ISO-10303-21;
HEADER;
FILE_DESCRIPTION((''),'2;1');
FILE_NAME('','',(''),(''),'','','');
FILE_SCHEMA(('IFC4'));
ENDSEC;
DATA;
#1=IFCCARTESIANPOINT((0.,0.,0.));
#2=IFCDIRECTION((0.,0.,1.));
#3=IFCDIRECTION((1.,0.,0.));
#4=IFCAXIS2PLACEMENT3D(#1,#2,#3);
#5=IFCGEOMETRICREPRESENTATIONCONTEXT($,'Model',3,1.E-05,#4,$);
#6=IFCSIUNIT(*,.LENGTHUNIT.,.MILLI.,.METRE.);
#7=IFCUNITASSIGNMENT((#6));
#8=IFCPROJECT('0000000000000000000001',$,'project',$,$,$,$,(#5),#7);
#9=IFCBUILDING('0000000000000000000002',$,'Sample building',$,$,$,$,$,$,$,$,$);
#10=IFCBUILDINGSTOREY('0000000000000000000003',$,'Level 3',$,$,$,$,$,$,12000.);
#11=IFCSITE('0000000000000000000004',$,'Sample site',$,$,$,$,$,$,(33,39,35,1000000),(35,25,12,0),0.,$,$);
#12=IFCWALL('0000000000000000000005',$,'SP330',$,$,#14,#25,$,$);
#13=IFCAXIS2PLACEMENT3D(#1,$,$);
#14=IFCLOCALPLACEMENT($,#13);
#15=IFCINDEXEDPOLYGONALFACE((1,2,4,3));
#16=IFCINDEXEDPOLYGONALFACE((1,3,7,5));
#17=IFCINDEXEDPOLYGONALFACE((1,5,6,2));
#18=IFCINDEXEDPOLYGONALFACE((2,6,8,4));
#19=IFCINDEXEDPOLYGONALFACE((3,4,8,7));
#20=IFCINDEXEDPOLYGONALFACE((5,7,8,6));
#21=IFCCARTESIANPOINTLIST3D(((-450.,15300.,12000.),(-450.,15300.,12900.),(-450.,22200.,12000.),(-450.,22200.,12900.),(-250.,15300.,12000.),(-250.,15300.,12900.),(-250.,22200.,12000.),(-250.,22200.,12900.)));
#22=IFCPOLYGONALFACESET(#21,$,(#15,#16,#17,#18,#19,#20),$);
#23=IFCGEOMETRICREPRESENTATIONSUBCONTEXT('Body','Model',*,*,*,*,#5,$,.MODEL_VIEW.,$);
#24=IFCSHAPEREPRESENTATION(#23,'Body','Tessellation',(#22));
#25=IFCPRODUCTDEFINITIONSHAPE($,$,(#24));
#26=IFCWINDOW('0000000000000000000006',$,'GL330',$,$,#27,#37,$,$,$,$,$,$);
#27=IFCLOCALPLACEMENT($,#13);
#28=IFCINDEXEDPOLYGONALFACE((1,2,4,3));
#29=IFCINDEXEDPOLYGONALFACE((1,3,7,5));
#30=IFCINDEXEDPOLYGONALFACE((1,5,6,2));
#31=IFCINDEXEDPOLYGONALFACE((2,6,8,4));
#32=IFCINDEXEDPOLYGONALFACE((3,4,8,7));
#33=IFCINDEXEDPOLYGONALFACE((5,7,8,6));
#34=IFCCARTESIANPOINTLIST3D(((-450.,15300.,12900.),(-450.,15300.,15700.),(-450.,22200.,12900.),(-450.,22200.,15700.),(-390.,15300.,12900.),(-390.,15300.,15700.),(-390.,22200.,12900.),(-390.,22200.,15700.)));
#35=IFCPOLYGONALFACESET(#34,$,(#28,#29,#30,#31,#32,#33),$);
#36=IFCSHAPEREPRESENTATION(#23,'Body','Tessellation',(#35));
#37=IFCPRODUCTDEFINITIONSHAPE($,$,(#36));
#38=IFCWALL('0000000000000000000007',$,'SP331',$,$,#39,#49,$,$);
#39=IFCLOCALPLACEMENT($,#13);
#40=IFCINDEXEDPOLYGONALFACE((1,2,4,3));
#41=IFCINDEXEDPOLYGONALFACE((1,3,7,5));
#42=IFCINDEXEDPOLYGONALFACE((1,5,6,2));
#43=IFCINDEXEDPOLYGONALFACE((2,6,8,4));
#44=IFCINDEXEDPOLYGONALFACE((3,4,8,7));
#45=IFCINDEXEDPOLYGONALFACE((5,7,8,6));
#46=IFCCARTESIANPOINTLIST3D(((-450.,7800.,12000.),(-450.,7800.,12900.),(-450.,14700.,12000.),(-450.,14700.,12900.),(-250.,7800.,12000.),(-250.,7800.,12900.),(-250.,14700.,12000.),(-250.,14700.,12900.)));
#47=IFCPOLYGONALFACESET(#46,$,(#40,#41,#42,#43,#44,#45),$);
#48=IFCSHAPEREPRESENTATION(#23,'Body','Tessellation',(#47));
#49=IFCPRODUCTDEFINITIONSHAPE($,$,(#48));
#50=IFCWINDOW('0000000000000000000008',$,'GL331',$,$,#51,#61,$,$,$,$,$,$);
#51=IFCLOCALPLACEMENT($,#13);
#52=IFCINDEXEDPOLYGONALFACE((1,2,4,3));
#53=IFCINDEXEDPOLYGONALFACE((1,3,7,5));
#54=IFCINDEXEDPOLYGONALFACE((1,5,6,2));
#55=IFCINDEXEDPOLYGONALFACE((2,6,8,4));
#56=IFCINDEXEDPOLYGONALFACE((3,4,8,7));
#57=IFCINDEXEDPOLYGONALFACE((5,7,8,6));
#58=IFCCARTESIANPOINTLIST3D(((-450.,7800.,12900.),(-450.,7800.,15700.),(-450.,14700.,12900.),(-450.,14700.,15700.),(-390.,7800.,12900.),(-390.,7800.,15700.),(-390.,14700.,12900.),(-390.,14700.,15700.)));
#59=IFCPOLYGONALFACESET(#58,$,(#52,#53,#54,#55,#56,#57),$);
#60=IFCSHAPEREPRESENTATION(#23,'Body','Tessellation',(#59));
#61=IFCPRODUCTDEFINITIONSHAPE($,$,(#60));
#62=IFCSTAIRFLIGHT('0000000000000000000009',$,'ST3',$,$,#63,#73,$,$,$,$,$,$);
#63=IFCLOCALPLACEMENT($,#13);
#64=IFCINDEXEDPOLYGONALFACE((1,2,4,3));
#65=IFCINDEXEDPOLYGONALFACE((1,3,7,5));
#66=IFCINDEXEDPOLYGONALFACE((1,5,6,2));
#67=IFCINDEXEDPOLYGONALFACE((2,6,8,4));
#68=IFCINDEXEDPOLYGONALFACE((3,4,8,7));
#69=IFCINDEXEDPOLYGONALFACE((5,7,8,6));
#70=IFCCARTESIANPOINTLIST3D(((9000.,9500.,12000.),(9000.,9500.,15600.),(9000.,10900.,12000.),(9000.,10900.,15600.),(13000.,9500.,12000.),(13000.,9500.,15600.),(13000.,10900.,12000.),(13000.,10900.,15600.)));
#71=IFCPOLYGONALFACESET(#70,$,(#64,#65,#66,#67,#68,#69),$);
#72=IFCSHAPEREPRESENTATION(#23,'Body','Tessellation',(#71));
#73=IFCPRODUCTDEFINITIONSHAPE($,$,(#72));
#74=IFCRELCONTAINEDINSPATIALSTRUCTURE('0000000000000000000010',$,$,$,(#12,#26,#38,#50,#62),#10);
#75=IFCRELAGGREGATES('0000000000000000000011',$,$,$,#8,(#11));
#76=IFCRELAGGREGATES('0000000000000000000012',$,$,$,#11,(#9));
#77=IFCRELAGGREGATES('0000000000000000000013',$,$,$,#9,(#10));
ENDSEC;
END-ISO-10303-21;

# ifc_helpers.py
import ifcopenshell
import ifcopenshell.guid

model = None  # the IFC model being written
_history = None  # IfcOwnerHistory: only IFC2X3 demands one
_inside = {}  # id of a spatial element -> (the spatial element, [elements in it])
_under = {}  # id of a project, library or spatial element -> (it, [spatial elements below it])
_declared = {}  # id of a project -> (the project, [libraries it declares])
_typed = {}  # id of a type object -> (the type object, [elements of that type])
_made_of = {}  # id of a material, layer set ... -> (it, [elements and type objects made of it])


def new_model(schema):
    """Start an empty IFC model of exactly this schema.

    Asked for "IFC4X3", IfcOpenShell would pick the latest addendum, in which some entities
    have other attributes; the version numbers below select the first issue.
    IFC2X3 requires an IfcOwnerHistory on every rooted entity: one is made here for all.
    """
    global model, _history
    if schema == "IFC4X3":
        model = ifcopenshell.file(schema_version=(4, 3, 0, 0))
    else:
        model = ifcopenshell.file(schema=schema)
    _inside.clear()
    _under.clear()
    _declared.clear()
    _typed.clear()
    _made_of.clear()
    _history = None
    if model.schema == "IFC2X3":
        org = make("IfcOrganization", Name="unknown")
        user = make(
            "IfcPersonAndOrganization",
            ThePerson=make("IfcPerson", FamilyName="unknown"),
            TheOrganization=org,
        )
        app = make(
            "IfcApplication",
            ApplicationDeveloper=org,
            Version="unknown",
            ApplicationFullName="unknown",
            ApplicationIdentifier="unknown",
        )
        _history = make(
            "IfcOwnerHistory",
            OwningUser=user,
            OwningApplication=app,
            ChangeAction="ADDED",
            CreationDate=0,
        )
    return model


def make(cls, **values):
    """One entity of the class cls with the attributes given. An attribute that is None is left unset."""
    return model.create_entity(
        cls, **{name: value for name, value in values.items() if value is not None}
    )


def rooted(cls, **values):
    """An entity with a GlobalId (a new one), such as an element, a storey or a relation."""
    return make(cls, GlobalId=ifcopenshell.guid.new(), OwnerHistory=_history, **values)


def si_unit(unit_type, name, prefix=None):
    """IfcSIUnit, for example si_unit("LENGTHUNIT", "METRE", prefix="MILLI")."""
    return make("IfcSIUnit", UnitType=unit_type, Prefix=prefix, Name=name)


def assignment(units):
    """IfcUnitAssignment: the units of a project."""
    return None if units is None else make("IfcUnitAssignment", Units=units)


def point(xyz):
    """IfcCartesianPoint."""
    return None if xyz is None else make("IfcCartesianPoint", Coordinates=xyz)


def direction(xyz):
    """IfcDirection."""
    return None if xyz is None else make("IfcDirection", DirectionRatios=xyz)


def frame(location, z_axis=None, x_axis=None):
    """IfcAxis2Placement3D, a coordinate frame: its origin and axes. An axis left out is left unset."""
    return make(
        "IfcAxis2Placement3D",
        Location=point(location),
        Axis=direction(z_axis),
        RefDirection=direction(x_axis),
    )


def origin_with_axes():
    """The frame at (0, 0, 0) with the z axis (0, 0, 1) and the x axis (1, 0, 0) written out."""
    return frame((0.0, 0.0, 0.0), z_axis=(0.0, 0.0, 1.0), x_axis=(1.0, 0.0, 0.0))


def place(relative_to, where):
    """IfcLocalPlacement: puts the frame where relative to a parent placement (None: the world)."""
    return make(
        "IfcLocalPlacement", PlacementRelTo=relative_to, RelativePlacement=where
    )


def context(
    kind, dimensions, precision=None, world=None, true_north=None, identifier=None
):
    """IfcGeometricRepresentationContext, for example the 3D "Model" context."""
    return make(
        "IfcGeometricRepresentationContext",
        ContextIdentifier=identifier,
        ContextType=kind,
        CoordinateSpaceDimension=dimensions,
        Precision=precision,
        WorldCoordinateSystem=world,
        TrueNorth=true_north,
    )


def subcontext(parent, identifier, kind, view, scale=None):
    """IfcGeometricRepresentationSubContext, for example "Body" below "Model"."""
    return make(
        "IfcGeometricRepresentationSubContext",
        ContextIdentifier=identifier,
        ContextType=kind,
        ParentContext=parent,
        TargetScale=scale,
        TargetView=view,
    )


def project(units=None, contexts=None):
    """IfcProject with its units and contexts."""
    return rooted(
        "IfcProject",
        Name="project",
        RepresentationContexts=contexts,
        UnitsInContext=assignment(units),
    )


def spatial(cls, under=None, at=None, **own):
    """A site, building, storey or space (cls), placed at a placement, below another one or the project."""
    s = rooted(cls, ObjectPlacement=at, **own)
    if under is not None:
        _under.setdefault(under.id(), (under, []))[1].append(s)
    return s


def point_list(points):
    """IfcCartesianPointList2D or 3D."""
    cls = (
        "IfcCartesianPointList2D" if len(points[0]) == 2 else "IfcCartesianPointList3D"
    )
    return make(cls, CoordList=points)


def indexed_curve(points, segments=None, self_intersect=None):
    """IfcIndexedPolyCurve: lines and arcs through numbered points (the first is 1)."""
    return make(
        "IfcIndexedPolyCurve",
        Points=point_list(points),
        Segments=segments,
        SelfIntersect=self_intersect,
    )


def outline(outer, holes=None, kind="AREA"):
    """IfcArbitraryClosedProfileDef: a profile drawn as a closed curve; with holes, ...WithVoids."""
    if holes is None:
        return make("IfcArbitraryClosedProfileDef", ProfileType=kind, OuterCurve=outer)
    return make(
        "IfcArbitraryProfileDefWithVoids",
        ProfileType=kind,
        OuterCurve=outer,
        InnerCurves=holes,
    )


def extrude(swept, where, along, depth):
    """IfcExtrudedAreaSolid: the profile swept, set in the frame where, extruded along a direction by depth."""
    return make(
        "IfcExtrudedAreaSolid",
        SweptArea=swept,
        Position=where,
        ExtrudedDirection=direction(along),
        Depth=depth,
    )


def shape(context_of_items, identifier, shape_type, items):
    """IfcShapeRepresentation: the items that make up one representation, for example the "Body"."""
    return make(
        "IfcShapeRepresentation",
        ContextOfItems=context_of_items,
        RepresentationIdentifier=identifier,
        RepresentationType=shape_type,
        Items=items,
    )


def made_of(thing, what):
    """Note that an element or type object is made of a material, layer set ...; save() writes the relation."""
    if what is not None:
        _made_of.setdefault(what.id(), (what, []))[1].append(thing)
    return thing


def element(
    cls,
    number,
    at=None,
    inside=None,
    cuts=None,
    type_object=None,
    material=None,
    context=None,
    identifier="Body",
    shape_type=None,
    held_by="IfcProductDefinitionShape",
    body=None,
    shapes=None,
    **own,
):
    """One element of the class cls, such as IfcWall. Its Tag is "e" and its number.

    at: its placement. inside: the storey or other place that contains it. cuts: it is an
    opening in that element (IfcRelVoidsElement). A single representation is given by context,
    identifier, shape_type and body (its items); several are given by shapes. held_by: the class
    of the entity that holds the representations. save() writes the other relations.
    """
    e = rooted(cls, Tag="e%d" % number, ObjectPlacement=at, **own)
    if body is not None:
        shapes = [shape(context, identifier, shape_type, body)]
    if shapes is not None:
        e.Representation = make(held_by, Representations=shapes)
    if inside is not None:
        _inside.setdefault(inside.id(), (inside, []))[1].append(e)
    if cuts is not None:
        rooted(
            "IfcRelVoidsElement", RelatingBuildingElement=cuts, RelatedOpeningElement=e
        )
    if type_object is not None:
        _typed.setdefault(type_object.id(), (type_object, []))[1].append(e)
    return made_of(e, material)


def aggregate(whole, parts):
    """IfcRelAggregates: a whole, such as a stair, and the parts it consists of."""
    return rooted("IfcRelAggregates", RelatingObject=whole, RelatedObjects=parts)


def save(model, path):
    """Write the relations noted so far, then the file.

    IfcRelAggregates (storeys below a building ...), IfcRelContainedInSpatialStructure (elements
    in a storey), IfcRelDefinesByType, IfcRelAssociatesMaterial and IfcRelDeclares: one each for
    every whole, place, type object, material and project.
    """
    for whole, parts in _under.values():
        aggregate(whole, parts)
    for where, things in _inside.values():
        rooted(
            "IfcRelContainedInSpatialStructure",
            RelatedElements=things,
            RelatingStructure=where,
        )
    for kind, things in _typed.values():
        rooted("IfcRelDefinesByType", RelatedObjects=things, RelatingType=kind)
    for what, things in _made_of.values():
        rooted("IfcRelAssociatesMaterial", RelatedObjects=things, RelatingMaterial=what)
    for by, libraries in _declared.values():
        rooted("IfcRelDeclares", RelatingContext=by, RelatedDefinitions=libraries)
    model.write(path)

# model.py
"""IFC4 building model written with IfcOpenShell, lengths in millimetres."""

from ifc_helpers import new_model, si_unit, frame, origin_with_axes, place, context, subcontext, project, spatial, indexed_curve, outline, extrude, element, save


model = new_model("IFC4")

# Units and contexts
model_context = context("Model", 3, precision=1e-05, world=origin_with_axes())
body_context = subcontext(model_context, "Body", "Model", "MODEL_VIEW")
ifc_project = project(units=[si_unit("LENGTHUNIT", "METRE", prefix="MILLI")], contexts=[model_context])

# Site, building, storey
site = spatial("IfcSite", under=ifc_project, Name="Sample site", RefLatitude=(33, 39, 35, 1000000), RefLongitude=(35, 25, 12, 0), RefElevation=0.0)
building = spatial("IfcBuilding", under=site, Name="Sample building")
storey = spatial("IfcBuildingStorey", under=building, Name="Level 3", Elevation=12000.0)

# Wall
wall_1_placement = place(None, frame((-450.0, 22200.0, 12000.0), z_axis=(0.0, 0.0, 1.0), x_axis=(0.0, -1.0, 0.0)))
element("IfcWall", 1, at=wall_1_placement, inside=storey, Name="SP330", context=body_context, shape_type="SweptSolid", body=[
    extrude(outline(indexed_curve([(0.0, 0.0), (0.0, 200.0), (6900.0, 200.0), (6900.0, 0.0), (0.0, 0.0)], self_intersect=False)), origin_with_axes(), (0.0, 0.0, 1.0), 900.0),
])

# Window
window_1_placement = place(None, frame((-450.0, 22200.0, 12900.0), z_axis=(0.0, 0.0, 1.0), x_axis=(0.0, -1.0, 0.0)))
element("IfcWindow", 2, at=window_1_placement, inside=storey, Name="GL330", context=body_context, shape_type="SweptSolid", body=[
    extrude(outline(indexed_curve([(0.0, 0.0), (0.0, 60.0), (6900.0, 60.0), (6900.0, 0.0), (0.0, 0.0)], self_intersect=False)), origin_with_axes(), (0.0, 0.0, 1.0), 2800.0),
])

# Wall
wall_2_placement = place(None, frame((-450.0, 14700.0, 12000.0), z_axis=(0.0, 0.0, 1.0), x_axis=(0.0, -1.0, 0.0)))
element("IfcWall", 3, at=wall_2_placement, inside=storey, Name="SP331", context=body_context, shape_type="SweptSolid", body=[
    extrude(outline(indexed_curve([(0.0, 0.0), (0.0, 200.0), (6900.0, 200.0), (6900.0, 0.0), (0.0, 0.0)], self_intersect=False)), origin_with_axes(), (0.0, 0.0, 1.0), 900.0),
])

# Window
window_2_placement = place(None, frame((-450.0, 14700.0, 12900.0), z_axis=(0.0, 0.0, 1.0), x_axis=(0.0, -1.0, 0.0)))
element("IfcWindow", 4, at=window_2_placement, inside=storey, Name="GL331", context=body_context, shape_type="SweptSolid", body=[
    extrude(outline(indexed_curve([(0.0, 0.0), (0.0, 60.0), (6900.0, 60.0), (6900.0, 0.0), (0.0, 0.0)], self_intersect=False)), origin_with_axes(), (0.0, 0.0, 1.0), 2800.0),
])

# Stair flight
stair_flight_placement = place(None, frame((9000.0, 9500.0, 12000.0), z_axis=(0.0, 0.0, 1.0), x_axis=(1.0, 0.0, 0.0)))
element("IfcStairFlight", 5, at=stair_flight_placement, inside=storey, Name="ST3", context=body_context, shape_type="SweptSolid", body=[
    extrude(outline(indexed_curve([(0.0, 0.0), (0.0, 1400.0), (4000.0, 1400.0), (4000.0, 0.0), (0.0, 0.0)], self_intersect=False)), origin_with_axes(), (0.0, 0.0, 1.0), 3600.0),
])

save(model, "model.ifc")
